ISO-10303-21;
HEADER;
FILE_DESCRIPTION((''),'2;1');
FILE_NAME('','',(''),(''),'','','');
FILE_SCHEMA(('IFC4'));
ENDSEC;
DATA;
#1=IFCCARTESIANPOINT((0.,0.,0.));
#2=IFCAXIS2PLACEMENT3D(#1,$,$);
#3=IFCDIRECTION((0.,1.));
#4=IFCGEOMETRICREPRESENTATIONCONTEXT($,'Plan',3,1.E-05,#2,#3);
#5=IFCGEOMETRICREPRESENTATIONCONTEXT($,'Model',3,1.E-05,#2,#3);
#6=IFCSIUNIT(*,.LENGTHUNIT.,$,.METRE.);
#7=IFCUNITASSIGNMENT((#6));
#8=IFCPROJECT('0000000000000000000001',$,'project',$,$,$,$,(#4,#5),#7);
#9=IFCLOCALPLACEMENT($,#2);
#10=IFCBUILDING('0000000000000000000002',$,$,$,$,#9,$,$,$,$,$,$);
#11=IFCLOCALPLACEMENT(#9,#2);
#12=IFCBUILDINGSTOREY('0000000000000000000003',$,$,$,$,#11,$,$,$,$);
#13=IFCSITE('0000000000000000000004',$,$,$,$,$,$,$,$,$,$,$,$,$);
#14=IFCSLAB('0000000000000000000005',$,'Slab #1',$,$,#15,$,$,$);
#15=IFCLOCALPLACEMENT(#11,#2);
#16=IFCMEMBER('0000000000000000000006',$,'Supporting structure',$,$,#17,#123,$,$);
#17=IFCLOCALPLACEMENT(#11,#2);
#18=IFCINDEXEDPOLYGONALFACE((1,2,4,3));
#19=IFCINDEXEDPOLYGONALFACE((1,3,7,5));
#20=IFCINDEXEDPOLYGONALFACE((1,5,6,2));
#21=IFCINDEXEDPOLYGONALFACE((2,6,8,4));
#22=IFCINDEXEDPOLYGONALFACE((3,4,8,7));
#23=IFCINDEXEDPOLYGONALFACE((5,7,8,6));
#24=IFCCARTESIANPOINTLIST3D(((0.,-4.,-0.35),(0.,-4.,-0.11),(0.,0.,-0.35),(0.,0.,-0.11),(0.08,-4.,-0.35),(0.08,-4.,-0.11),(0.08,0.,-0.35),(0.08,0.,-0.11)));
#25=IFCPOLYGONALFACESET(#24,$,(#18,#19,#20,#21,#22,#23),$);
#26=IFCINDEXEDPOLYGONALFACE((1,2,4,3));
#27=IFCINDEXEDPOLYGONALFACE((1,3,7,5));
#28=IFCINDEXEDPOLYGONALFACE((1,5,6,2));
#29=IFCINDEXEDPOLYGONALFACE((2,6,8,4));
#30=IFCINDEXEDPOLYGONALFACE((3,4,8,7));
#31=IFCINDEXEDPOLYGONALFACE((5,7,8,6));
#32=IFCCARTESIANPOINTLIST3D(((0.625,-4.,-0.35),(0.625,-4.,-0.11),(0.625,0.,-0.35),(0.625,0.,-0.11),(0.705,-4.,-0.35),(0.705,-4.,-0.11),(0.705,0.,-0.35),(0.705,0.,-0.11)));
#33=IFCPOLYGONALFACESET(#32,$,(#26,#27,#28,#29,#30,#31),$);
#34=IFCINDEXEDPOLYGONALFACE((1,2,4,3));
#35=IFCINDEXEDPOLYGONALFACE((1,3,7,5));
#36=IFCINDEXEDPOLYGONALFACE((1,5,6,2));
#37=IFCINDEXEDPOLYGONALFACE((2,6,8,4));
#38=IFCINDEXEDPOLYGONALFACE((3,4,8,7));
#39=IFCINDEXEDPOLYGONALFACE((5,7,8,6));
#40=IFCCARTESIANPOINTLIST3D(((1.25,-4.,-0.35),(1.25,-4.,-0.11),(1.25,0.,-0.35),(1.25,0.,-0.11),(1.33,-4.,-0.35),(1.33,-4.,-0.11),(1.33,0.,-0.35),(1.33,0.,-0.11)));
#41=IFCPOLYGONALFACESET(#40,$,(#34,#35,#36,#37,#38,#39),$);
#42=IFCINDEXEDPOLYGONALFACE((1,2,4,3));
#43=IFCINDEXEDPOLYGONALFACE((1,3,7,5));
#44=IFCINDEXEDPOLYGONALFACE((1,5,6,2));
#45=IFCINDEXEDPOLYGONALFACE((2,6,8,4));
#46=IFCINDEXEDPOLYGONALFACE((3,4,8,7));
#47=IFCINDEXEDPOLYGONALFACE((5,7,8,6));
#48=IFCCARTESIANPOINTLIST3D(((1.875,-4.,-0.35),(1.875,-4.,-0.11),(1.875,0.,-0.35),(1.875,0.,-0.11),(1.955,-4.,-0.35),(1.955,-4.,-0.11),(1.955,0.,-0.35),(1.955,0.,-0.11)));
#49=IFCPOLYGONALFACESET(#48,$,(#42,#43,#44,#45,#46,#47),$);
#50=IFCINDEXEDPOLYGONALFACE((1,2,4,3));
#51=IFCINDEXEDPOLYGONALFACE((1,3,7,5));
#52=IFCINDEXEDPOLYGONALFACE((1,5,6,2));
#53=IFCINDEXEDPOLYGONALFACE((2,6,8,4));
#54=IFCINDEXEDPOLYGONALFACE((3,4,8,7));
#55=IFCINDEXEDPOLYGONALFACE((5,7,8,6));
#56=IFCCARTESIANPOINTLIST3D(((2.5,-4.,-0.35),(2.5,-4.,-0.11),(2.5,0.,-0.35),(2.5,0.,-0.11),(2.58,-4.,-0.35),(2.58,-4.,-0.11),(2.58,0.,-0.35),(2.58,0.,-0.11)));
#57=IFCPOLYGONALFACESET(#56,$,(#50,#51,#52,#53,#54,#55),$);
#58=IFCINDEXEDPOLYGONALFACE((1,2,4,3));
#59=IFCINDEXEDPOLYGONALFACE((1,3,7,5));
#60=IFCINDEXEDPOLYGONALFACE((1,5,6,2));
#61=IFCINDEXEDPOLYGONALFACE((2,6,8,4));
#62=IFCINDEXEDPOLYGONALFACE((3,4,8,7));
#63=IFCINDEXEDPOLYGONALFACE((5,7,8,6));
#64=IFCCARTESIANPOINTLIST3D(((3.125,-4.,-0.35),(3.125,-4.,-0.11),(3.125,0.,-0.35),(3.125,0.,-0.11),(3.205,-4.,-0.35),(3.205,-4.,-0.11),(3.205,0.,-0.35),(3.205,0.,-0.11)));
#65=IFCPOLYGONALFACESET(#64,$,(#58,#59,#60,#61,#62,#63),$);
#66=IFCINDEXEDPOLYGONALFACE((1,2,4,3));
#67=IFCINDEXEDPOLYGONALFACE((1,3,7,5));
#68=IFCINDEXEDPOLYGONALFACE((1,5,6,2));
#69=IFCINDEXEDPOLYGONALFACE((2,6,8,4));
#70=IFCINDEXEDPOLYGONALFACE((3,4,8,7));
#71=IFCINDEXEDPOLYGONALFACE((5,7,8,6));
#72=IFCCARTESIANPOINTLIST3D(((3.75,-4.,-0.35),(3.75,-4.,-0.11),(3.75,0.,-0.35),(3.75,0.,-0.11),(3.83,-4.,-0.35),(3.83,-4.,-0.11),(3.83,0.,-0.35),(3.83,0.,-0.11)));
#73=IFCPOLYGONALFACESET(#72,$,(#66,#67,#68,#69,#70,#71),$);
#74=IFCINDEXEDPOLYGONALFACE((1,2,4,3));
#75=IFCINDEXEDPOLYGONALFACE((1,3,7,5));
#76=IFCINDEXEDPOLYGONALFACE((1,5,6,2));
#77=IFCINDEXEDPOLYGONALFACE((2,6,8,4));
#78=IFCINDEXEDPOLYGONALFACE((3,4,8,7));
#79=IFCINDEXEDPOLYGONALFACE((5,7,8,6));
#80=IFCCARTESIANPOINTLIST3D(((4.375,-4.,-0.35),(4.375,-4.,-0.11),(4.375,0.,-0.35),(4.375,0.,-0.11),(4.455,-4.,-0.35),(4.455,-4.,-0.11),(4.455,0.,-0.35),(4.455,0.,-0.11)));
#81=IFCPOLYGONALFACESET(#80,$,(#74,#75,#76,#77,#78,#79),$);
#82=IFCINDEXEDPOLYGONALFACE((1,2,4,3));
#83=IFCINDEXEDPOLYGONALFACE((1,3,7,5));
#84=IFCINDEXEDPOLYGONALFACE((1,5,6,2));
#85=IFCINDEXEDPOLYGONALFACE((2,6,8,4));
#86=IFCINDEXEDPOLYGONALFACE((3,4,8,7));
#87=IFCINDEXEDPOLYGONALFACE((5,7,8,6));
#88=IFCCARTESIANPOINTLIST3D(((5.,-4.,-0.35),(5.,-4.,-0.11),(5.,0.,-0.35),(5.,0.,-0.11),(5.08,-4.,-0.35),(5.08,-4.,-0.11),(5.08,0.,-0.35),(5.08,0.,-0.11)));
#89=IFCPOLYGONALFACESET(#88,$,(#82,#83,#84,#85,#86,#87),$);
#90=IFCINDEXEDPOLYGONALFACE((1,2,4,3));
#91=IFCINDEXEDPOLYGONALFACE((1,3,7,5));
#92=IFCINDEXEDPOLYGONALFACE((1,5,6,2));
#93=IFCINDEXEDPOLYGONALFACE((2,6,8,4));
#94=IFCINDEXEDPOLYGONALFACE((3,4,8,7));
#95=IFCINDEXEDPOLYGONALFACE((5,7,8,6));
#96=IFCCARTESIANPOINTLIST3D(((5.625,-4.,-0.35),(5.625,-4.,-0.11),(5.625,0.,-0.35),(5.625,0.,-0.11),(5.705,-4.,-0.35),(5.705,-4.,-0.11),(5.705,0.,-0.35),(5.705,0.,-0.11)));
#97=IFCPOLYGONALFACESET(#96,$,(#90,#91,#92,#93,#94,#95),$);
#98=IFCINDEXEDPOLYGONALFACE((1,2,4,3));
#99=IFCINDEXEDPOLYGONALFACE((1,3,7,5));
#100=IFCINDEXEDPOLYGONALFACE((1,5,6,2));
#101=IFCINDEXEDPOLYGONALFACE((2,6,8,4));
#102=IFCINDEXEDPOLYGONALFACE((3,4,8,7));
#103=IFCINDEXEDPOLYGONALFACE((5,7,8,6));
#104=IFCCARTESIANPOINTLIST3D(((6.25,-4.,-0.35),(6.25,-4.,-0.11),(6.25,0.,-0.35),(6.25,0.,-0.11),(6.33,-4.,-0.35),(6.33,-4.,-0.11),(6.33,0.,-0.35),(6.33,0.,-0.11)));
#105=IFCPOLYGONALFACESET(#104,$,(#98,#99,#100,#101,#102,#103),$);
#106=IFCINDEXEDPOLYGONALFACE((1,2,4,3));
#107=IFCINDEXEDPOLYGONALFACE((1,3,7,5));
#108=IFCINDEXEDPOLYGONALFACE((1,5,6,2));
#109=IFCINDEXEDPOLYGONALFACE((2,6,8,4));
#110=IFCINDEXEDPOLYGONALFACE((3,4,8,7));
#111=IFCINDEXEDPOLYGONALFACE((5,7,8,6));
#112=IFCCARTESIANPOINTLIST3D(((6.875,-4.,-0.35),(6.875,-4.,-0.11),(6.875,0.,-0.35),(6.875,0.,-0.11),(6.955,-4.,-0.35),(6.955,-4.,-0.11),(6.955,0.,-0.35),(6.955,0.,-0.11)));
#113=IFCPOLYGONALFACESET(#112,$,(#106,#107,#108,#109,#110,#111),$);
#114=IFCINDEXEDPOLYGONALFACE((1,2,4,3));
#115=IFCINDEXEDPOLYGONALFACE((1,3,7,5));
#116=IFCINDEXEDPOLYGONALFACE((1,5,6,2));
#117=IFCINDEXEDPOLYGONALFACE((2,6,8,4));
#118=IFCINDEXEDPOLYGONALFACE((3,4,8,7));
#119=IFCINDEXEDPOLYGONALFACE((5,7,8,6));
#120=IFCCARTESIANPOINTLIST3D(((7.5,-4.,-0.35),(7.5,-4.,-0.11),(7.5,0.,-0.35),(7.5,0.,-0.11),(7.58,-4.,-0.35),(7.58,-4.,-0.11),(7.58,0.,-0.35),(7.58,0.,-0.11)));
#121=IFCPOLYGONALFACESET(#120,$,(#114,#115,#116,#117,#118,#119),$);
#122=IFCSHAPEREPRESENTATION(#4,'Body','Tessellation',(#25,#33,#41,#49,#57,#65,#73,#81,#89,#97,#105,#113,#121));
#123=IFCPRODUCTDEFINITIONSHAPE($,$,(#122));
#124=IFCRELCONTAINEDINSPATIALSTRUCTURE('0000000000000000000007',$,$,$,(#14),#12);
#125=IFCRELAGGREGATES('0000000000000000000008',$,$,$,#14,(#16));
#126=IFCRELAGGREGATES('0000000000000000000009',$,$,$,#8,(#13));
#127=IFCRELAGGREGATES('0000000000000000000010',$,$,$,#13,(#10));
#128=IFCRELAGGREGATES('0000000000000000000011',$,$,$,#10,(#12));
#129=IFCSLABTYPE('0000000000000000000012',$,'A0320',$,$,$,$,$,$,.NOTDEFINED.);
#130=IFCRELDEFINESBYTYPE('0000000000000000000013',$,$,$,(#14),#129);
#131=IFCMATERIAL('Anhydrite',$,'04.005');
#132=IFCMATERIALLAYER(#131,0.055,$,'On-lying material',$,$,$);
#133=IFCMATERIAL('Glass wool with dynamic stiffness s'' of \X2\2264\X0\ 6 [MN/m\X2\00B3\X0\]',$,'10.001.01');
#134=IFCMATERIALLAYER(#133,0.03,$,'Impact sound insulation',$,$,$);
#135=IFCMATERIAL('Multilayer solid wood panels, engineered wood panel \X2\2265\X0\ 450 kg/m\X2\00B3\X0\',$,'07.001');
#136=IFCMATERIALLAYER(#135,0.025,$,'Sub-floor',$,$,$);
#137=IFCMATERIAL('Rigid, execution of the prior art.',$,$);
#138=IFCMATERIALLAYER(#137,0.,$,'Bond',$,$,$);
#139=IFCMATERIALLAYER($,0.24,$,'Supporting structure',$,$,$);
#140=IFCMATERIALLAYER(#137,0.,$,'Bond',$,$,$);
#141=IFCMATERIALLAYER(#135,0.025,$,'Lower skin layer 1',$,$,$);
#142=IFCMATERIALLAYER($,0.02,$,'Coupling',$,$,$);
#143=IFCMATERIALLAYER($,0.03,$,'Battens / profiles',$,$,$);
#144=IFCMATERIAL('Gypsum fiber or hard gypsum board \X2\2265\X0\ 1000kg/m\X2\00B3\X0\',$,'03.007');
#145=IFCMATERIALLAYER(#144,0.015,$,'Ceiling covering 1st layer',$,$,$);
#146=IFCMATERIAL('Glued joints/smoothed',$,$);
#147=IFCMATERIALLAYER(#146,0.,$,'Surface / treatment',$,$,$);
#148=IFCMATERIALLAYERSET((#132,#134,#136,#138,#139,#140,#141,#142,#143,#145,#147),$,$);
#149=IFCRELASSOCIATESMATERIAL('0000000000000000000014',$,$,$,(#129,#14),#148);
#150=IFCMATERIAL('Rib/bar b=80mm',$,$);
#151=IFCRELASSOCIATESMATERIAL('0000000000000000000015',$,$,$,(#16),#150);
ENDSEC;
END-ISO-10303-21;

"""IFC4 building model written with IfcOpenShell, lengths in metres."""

from ifc_helpers import new_model, si_unit, direction, frame, frame_2d, origin, place, context, project, spatial, rectangle, extrude, material, layer, layer_set, type_object, element, aggregate, save


model = new_model("IFC4")

# Units and contexts
plan_context = context("Plan", 3, precision=1e-05, world=origin(), true_north=direction((0.0, 1.0)))
model_context = context("Model", 3, precision=1e-05, world=origin(), true_north=direction((0.0, 1.0)))
ifc_project = project(units=[si_unit("LENGTHUNIT", "METRE")], contexts=[plan_context, model_context])

# Site, building, storey
site = spatial("IfcSite", under=ifc_project)
building_placement = place(None, origin())
building = spatial("IfcBuilding", under=site, at=building_placement)
storey_placement = place(building_placement, origin())
storey = spatial("IfcBuildingStorey", under=building, at=storey_placement)

# Slab, member
ifc_material_1 = material(Name="Anhydrite", Category="04.005")
ifc_layer_1 = layer(ifc_material_1, 0.055, Name="On-lying material")
ifc_material_2 = material(Name="Glass wool with dynamic stiffness s' of ≤ 6 [MN/m³]", Category="10.001.01")
ifc_layer_2 = layer(ifc_material_2, 0.03, Name="Impact sound insulation")
ifc_material_3 = material(Name="Multilayer solid wood panels, engineered wood panel ≥ 450 kg/m³", Category="07.001")
ifc_layer_3 = layer(ifc_material_3, 0.025, Name="Sub-floor")
ifc_material_4 = material(Name="Rigid, execution of the prior art.")
ifc_layer_4 = layer(ifc_material_4, 0.0, Name="Bond")
ifc_layer_5 = layer(None, 0.24, Name="Supporting structure")
ifc_layer_6 = layer(ifc_material_4, 0.0, Name="Bond")
ifc_layer_7 = layer(ifc_material_3, 0.025, Name="Lower skin layer 1")
ifc_layer_8 = layer(None, 0.02, Name="Coupling")
ifc_layer_9 = layer(None, 0.03, Name="Battens / profiles")
ifc_material_5 = material(Name="Gypsum fiber or hard gypsum board ≥ 1000kg/m³", Category="03.007")
ifc_layer_10 = layer(ifc_material_5, 0.015, Name="Ceiling covering 1st layer")
ifc_material_6 = material(Name="Glued joints/smoothed")
ifc_layer_11 = layer(ifc_material_6, 0.0, Name="Surface / treatment")
ifc_layer_set = layer_set([ifc_layer_1, ifc_layer_2, ifc_layer_3, ifc_layer_4, ifc_layer_5, ifc_layer_6, ifc_layer_7, ifc_layer_8, ifc_layer_9, ifc_layer_10, ifc_layer_11])
slab_type = type_object("IfcSlabType", Name="A0320", PredefinedType="NOTDEFINED", material=ifc_layer_set)
slab_placement = place(None, frame((0.0, 0.0, 0.0), z_axis=(0.0, 0.0, -1.0), x_axis=(1.0, 0.0, 0.0)))
slab = element("IfcSlab", 1, at=slab_placement, inside=storey, type_object=slab_type, material=ifc_layer_set, Name="Slab #1")
ifc_material_7 = material(Name="Rib/bar b=80mm")
member_1_placement = place(slab_placement, origin())
member_1 = element("IfcMember", 2, at=member_1_placement, material=ifc_material_7, Name="Supporting structure", context=plan_context, shape_type="SweptSolid", body=[
    extrude(rectangle(XDim=0.08, YDim=0.24, at=frame_2d((0.04, 0.12), x_axis=(1.0, 0.0))), frame((0.0, 4.0, 0.11), z_axis=(0.0, -1.0, 0.0), x_axis=(1.0, 0.0, 0.0)), (0.0, 0.0, 1.0), 4.0),
    extrude(rectangle(XDim=0.08, YDim=0.24, at=frame_2d((0.04, 0.12), x_axis=(1.0, 0.0))), frame((0.625, 4.0, 0.11), z_axis=(0.0, -1.0, 0.0), x_axis=(1.0, 0.0, 0.0)), (0.0, 0.0, 1.0), 4.0),
    extrude(rectangle(XDim=0.08, YDim=0.24, at=frame_2d((0.04, 0.12), x_axis=(1.0, 0.0))), frame((1.25, 4.0, 0.11), z_axis=(0.0, -1.0, 0.0), x_axis=(1.0, 0.0, 0.0)), (0.0, 0.0, 1.0), 4.0),
    extrude(rectangle(XDim=0.08, YDim=0.24, at=frame_2d((0.04, 0.12), x_axis=(1.0, 0.0))), frame((1.875, 4.0, 0.11), z_axis=(0.0, -1.0, 0.0), x_axis=(1.0, 0.0, 0.0)), (0.0, 0.0, 1.0), 4.0),
    extrude(rectangle(XDim=0.08, YDim=0.24, at=frame_2d((0.04, 0.12), x_axis=(1.0, 0.0))), frame((2.5, 4.0, 0.11), z_axis=(0.0, -1.0, 0.0), x_axis=(1.0, 0.0, 0.0)), (0.0, 0.0, 1.0), 4.0),
    extrude(rectangle(XDim=0.08, YDim=0.24, at=frame_2d((0.04, 0.12), x_axis=(1.0, 0.0))), frame((3.125, 4.0, 0.11), z_axis=(0.0, -1.0, 0.0), x_axis=(1.0, 0.0, 0.0)), (0.0, 0.0, 1.0), 4.0),
    extrude(rectangle(XDim=0.08, YDim=0.24, at=frame_2d((0.04, 0.12), x_axis=(1.0, 0.0))), frame((3.75, 4.0, 0.11), z_axis=(0.0, -1.0, 0.0), x_axis=(1.0, 0.0, 0.0)), (0.0, 0.0, 1.0), 4.0),
    extrude(rectangle(XDim=0.08, YDim=0.24, at=frame_2d((0.04, 0.12), x_axis=(1.0, 0.0))), frame((4.375, 4.0, 0.11), z_axis=(0.0, -1.0, 0.0), x_axis=(1.0, 0.0, 0.0)), (0.0, 0.0, 1.0), 4.0),
    extrude(rectangle(XDim=0.08, YDim=0.24, at=frame_2d((0.04, 0.12), x_axis=(1.0, 0.0))), frame((5.0, 4.0, 0.11), z_axis=(0.0, -1.0, 0.0), x_axis=(1.0, 0.0, 0.0)), (0.0, 0.0, 1.0), 4.0),
    extrude(rectangle(XDim=0.08, YDim=0.24, at=frame_2d((0.04, 0.12), x_axis=(1.0, 0.0))), frame((5.625, 4.0, 0.11), z_axis=(0.0, -1.0, 0.0), x_axis=(1.0, 0.0, 0.0)), (0.0, 0.0, 1.0), 4.0),
    extrude(rectangle(XDim=0.08, YDim=0.24, at=frame_2d((0.04, 0.12), x_axis=(1.0, 0.0))), frame((6.25, 4.0, 0.11), z_axis=(0.0, -1.0, 0.0), x_axis=(1.0, 0.0, 0.0)), (0.0, 0.0, 1.0), 4.0),
    extrude(rectangle(XDim=0.08, YDim=0.24, at=frame_2d((0.04, 0.12), x_axis=(1.0, 0.0))), frame((6.875, 4.0, 0.11), z_axis=(0.0, -1.0, 0.0), x_axis=(1.0, 0.0, 0.0)), (0.0, 0.0, 1.0), 4.0),
    extrude(rectangle(XDim=0.08, YDim=0.24, at=frame_2d((0.04, 0.12), x_axis=(1.0, 0.0))), frame((7.5, 4.0, 0.11), z_axis=(0.0, -1.0, 0.0), x_axis=(1.0, 0.0, 0.0)), (0.0, 0.0, 1.0), 4.0),
])
aggregate(slab, [member_1])

save(model, "model.ifc")
